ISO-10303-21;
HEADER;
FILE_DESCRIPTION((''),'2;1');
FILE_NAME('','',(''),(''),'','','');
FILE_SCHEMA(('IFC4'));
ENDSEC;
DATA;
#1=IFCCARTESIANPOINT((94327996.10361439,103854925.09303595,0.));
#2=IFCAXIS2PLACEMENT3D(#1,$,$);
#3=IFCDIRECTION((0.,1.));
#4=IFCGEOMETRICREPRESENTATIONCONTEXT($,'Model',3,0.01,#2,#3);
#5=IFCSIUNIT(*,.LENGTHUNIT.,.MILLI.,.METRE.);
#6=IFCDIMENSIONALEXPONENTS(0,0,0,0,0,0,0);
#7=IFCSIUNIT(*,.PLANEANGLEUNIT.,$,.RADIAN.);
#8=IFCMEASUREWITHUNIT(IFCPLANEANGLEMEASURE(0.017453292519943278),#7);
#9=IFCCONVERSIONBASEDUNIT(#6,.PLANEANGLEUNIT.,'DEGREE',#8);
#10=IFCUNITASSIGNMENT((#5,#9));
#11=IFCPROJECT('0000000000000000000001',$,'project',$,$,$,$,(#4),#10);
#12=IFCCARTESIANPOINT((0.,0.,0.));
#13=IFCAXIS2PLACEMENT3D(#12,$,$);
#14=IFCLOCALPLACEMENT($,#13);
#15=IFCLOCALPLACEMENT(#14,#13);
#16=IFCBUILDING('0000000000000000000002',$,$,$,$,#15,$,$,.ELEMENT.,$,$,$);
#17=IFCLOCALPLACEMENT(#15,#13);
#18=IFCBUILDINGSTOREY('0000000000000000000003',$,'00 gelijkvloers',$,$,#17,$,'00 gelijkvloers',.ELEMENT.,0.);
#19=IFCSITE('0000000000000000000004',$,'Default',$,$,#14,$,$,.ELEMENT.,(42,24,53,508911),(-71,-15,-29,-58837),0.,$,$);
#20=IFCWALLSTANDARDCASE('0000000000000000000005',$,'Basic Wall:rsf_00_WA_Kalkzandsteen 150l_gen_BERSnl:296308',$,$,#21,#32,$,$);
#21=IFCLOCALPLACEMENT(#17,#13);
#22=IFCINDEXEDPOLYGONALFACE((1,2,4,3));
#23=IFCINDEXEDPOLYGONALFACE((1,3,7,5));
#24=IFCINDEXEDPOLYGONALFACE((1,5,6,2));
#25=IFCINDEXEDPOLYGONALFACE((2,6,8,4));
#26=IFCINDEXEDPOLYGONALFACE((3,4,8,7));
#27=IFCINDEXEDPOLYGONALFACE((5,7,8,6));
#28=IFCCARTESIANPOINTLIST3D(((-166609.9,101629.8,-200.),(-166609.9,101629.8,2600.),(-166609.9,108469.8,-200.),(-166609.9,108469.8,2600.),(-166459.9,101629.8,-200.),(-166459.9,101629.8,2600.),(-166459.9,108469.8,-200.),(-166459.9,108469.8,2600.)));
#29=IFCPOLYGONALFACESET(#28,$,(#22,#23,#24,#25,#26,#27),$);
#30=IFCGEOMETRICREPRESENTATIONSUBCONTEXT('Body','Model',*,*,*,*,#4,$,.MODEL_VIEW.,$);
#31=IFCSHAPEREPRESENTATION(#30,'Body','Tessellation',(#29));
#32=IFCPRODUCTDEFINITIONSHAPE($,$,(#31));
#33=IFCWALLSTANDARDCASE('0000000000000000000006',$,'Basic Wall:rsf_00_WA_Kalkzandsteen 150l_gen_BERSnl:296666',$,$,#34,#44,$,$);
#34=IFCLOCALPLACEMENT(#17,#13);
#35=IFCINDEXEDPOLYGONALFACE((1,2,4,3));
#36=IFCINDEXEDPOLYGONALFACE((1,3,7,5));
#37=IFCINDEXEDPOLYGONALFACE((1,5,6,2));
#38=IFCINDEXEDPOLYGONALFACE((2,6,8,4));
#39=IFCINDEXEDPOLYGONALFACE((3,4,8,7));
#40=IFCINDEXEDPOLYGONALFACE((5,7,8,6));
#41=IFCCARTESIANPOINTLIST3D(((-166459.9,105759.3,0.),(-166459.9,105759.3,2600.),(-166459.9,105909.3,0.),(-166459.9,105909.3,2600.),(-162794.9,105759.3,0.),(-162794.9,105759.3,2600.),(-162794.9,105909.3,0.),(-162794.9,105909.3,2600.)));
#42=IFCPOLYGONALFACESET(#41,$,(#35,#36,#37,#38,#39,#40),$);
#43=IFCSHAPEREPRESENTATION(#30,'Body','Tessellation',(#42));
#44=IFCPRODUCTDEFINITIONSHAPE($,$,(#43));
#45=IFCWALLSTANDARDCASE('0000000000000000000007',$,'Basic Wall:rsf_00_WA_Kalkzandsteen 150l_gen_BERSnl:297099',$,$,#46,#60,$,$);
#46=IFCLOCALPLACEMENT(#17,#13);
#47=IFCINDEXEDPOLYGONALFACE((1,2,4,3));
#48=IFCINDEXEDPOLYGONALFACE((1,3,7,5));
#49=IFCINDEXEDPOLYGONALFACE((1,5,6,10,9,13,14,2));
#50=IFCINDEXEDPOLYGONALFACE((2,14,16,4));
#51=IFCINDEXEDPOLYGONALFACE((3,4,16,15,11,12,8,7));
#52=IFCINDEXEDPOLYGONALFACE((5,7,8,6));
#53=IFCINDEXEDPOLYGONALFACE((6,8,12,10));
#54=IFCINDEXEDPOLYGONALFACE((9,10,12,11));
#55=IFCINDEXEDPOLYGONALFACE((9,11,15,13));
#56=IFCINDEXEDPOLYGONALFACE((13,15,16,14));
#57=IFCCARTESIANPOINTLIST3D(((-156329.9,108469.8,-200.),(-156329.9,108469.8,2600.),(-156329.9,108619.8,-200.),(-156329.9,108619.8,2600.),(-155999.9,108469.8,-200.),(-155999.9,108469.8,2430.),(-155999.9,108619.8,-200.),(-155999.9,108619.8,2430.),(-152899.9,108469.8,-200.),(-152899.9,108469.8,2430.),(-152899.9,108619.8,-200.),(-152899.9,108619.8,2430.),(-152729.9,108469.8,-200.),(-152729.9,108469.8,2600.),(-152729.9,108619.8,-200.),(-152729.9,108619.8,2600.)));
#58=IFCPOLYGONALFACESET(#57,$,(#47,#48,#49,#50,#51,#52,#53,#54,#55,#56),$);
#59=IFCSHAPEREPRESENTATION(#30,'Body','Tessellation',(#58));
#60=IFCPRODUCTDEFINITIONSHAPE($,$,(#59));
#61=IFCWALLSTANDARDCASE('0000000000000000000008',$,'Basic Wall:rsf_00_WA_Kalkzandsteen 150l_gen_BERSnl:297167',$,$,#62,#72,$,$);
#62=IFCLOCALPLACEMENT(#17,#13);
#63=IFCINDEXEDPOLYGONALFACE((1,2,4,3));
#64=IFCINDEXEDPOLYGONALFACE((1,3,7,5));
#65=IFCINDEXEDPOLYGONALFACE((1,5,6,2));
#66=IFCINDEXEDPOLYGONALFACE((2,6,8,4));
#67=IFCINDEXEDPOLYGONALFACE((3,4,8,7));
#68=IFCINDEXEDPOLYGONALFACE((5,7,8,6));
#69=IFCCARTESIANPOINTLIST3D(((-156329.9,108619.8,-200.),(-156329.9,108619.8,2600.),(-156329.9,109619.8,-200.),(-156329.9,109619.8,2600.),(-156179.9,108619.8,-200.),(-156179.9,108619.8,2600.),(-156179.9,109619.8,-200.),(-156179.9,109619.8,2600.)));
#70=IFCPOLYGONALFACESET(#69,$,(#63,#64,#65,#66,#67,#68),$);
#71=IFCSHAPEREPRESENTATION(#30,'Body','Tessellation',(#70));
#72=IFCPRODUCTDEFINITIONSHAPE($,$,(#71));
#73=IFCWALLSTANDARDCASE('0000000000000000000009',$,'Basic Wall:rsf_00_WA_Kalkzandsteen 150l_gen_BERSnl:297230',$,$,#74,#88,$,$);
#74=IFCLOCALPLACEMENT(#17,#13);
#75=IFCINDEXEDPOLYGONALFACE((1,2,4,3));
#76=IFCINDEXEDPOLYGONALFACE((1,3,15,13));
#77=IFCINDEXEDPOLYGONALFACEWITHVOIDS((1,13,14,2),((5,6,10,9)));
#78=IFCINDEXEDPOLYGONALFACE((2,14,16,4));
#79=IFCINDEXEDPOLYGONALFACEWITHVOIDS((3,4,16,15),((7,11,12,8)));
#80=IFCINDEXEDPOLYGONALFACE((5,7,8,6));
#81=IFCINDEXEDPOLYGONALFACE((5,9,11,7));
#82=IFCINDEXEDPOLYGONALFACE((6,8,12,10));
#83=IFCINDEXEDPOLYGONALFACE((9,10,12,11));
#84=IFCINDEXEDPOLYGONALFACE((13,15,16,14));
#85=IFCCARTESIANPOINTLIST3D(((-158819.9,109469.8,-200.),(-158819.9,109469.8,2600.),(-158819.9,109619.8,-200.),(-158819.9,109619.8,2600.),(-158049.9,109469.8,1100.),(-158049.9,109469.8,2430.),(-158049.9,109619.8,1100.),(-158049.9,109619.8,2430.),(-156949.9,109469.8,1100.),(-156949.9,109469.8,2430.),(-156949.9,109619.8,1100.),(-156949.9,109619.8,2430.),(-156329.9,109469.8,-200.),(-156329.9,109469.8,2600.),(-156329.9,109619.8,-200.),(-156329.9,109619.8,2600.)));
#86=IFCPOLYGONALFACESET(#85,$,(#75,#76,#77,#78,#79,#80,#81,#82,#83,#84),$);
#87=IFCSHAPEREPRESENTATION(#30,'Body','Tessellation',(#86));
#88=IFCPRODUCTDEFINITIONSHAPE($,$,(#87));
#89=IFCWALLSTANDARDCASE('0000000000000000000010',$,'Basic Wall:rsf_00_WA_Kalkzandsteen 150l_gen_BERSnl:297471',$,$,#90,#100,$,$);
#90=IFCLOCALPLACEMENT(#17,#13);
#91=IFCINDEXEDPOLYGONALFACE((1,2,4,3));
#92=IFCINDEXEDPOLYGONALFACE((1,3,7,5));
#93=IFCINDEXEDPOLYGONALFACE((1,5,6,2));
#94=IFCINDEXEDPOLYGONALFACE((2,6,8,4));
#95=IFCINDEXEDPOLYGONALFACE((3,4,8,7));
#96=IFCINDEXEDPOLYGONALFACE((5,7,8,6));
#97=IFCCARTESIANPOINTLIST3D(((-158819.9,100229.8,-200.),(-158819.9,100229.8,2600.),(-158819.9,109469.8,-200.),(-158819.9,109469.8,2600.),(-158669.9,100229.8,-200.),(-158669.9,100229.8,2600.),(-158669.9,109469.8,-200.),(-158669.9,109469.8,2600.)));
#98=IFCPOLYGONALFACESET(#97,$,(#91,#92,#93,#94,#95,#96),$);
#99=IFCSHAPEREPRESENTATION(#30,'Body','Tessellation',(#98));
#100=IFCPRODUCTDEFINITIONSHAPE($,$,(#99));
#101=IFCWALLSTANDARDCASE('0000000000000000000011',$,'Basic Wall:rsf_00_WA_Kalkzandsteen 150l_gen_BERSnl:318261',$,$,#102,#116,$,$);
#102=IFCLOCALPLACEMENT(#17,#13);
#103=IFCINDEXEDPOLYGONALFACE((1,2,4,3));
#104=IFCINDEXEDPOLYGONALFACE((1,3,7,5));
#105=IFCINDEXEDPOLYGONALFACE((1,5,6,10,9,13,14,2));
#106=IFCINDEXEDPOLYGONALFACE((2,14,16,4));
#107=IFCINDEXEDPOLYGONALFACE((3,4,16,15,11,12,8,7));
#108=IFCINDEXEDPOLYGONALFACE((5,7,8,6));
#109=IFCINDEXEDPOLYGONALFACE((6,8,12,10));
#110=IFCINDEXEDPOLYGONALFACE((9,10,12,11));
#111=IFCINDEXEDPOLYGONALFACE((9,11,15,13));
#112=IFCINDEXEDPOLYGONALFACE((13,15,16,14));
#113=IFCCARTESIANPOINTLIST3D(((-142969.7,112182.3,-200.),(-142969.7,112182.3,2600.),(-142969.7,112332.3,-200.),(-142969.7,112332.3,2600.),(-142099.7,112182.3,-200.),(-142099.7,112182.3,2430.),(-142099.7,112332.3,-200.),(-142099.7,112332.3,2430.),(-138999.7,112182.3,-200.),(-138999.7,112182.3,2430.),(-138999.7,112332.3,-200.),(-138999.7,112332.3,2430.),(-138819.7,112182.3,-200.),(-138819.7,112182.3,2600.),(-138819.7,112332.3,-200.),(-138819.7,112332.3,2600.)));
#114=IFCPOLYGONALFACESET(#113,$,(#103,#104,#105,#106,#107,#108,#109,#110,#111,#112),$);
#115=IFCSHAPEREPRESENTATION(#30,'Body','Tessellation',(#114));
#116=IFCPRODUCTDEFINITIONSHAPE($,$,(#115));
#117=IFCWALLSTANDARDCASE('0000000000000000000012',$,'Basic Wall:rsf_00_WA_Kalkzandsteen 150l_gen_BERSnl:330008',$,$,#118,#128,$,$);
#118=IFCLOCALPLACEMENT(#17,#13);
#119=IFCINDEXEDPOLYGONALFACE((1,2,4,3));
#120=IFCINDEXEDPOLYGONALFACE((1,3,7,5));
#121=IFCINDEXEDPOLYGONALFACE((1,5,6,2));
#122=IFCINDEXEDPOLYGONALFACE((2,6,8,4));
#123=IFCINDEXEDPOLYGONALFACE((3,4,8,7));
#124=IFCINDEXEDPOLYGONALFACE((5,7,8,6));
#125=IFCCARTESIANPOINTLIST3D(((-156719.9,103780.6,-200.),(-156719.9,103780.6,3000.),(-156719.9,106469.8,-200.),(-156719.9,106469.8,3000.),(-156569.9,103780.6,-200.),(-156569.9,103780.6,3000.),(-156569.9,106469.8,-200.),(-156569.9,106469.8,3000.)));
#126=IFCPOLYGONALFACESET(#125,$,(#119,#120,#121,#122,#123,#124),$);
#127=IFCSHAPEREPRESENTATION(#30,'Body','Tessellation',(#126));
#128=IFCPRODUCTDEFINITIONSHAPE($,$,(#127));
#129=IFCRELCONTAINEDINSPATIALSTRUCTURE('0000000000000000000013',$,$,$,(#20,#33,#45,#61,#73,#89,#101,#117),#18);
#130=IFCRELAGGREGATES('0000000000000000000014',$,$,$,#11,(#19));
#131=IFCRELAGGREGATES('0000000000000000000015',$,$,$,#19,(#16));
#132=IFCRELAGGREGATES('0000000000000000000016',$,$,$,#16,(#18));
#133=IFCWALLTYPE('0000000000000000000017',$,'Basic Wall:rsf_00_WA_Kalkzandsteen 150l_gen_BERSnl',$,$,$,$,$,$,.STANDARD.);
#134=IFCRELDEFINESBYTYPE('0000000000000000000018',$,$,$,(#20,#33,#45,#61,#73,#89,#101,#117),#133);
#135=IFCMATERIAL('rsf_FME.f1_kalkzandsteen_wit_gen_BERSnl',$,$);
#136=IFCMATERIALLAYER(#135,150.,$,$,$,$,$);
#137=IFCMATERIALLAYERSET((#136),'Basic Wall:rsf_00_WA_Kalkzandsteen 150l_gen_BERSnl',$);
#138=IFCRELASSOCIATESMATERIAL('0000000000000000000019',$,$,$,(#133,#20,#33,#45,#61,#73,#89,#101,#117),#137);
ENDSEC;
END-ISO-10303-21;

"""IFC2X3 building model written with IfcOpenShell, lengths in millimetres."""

from ifc_helpers import new_model, entity, si_unit, converted_unit, direction, frame, frame_2d, origin, place, context, subcontext, project, spatial, polyline, rectangle, extrude, clip, bounded_halfspace, material, layer, layer_set, layer_usage, type_object, element, save


model = new_model("IFC2X3")

# Units and contexts
model_context = context("Model", 3, precision=0.01, world=frame((94327996.10361439, 103854925.09303595, 0.0)), true_north=direction((0.0, 1.0)))
body_context = subcontext(model_context, "Body", "Model", "MODEL_VIEW")
ifc_project = project(units=[si_unit("LENGTHUNIT", "METRE", prefix="MILLI"), converted_unit("PLANEANGLEUNIT", "DEGREE", entity("IfcPlaneAngleMeasure", 0.017453292519943278), si_unit("PLANEANGLEUNIT", "RADIAN"), dimensions=[0, 0, 0, 0, 0, 0, 0])], contexts=[model_context])

# Site, building, storey
site_placement = place(None, origin())
site = spatial("IfcSite", under=ifc_project, at=site_placement, Name="Default", CompositionType="ELEMENT", RefLatitude=(42, 24, 53, 508911), RefLongitude=(-71, -15, -29, -58837), RefElevation=0.0)
building_placement = place(site_placement, origin())
building = spatial("IfcBuilding", under=site, at=building_placement, CompositionType="ELEMENT")
storey_placement = place(building_placement, origin())
storey = spatial("IfcBuildingStorey", under=building, at=storey_placement, Name="00 gelijkvloers", LongName="00 gelijkvloers", CompositionType="ELEMENT", Elevation=0.0)

# Shared definitions
ifc_material_1 = material(Name="rsf_FME.f1_kalkzandsteen_wit_gen_BERSnl")
ifc_layer_1 = layer(ifc_material_1, 150.0)
ifc_layer_set_1 = layer_set([ifc_layer_1], Name="Basic Wall:rsf_00_WA_Kalkzandsteen 150l_gen_BERSnl")
wall_type_1 = type_object("IfcWallType", Name="Basic Wall:rsf_00_WA_Kalkzandsteen 150l_gen_BERSnl", PredefinedType="STANDARD", material=ifc_layer_set_1)

# Walls
ifc_layer_usage_1 = layer_usage(ifc_layer_set_1, "AXIS2", "NEGATIVE", 75.0)
wall_1_placement = place(storey_placement, frame((-166534.9, 108469.8, -200.0), z_axis=(0.0, 0.0, 1.0), x_axis=(0.0, -1.0, 0.0)))
element("IfcWallStandardCase", 1, at=wall_1_placement, inside=storey, type_object=wall_type_1, material=ifc_layer_usage_1, Name="Basic Wall:rsf_00_WA_Kalkzandsteen 150l_gen_BERSnl:296308", context=body_context, shape_type="Clipping", body=[
    clip(extrude(rectangle(XDim=6840.0, YDim=150.0, at=frame_2d((3420.0, 0.0), x_axis=(-1.0, 0.0))), origin(), (0.0, 0.0, 1.0), 2800.0), bounded_halfspace(frame((0.0, -75.0, 2800.0), z_axis=(0.0, 0.0, -1.0), x_axis=(-1.0, 0.0, 0.0)), True, frame((0.0, -75.0, 2800.0)), polyline([(0.0, 0.0), (6840.0, 0.0), (6840.0, 150.0), (2710.5, 150.0), (2560.5, 150.0), (0.0, 150.0), (0.0, 0.0)]))),
])
ifc_layer_usage_2 = layer_usage(ifc_layer_set_1, "AXIS2", "NEGATIVE", 75.0)
wall_2_placement = place(storey_placement, frame((-166459.9, 105834.3, 0.0)))
element("IfcWallStandardCase", 2, at=wall_2_placement, inside=storey, type_object=wall_type_1, material=ifc_layer_usage_2, Name="Basic Wall:rsf_00_WA_Kalkzandsteen 150l_gen_BERSnl:296666", context=body_context, shape_type="Clipping", body=[
    clip(extrude(rectangle(XDim=3665.0, YDim=150.0, at=frame_2d((1832.5, 0.0), x_axis=(-1.0, 0.0))), origin(), (0.0, 0.0, 1.0), 2600.0), bounded_halfspace(frame((0.0, -75.0, 2600.0), z_axis=(0.0, 0.0, -1.0), x_axis=(0.0, 1.0, 0.0)), True, frame((0.0, -75.0, 2600.0)), polyline([(0.0, 0.0), (3665.0, 0.0), (3665.0, 150.0), (0.0, 150.0), (0.0, 0.0)]))),
])

# Wall, opening
ifc_layer_usage_3 = layer_usage(ifc_layer_set_1, "AXIS2", "NEGATIVE", 75.0)
wall_3_placement = place(storey_placement, frame((-152729.9, 108544.8, -200.0), z_axis=(0.0, 0.0, 1.0), x_axis=(-1.0, 0.0, 0.0)))
wall_3 = element("IfcWallStandardCase", 3, at=wall_3_placement, inside=storey, type_object=wall_type_1, material=ifc_layer_usage_3, Name="Basic Wall:rsf_00_WA_Kalkzandsteen 150l_gen_BERSnl:297099", context=body_context, shape_type="Clipping", body=[
    clip(extrude(rectangle(XDim=3600.0, YDim=150.0, at=frame_2d((1800.0, 0.0), x_axis=(1.0, 0.0))), origin(), (0.0, 0.0, 1.0), 2800.0), bounded_halfspace(frame((0.0, -75.0, 2800.0), z_axis=(0.0, 0.0, -1.0), x_axis=(0.0, -1.0, 0.0)), True, frame((0.0, -75.0, 2800.0)), polyline([(0.0, 0.0), (3450.0, 0.0), (3600.0, 0.0), (3600.0, 150.0), (0.0, 150.0), (0.0, 0.0)]))),
])
opening_1_placement = place(wall_3_placement, frame((-152729.9, 108544.8, 200.0), z_axis=(0.0, 0.0, 1.0), x_axis=(-1.0, 0.0, 0.0)))
element("IfcOpeningElement", 4, at=opening_1_placement, cuts=wall_3, ObjectType="Opening", context=body_context, shape_type="SweptSolid", body=[
    extrude(rectangle(XDim=2630.0, YDim=3100.0, at=frame_2d((0.0, 0.0), x_axis=(0.0, 1.0))), frame((-154449.9, 110143.8, 1115.0), z_axis=(0.0, -1.0, 0.0), x_axis=(1.0, 0.0, 0.0)), (0.0, 0.0, 1.0), 3048.0),
])

# Wall
ifc_layer_usage_4 = layer_usage(ifc_layer_set_1, "AXIS2", "NEGATIVE", 75.0)
wall_4_placement = place(storey_placement, frame((-156254.9, 108619.8, -200.0), z_axis=(0.0, 0.0, 1.0), x_axis=(0.0, 1.0, 0.0)))
element("IfcWallStandardCase", 5, at=wall_4_placement, inside=storey, type_object=wall_type_1, material=ifc_layer_usage_4, Name="Basic Wall:rsf_00_WA_Kalkzandsteen 150l_gen_BERSnl:297167", context=body_context, shape_type="Clipping", body=[
    clip(extrude(rectangle(XDim=1000.0, YDim=150.0, at=frame_2d((500.0, 0.0), x_axis=(-1.0, 0.0))), origin(), (0.0, 0.0, 1.0), 2800.0), bounded_halfspace(frame((0.0, -75.0, 2800.0), z_axis=(0.0, 0.0, -1.0), x_axis=(1.0, 0.0, 0.0)), True, frame((0.0, -75.0, 2800.0)), polyline([(0.0, 0.0), (1000.0, 0.0), (1000.0, 150.0), (850.0, 150.0), (0.0, 150.0), (0.0, 0.0)]))),
])

# Wall, opening
ifc_layer_usage_5 = layer_usage(ifc_layer_set_1, "AXIS2", "NEGATIVE", 75.0)
wall_5_placement = place(storey_placement, frame((-156329.9, 109544.8, -200.0), z_axis=(0.0, 0.0, 1.0), x_axis=(-1.0, 0.0, 0.0)))
wall_5 = element("IfcWallStandardCase", 6, at=wall_5_placement, inside=storey, type_object=wall_type_1, material=ifc_layer_usage_5, Name="Basic Wall:rsf_00_WA_Kalkzandsteen 150l_gen_BERSnl:297230", context=body_context, shape_type="Clipping", body=[
    clip(extrude(rectangle(XDim=2490.0, YDim=150.0, at=frame_2d((1245.0, 0.0), x_axis=(-1.0, 0.0))), origin(), (0.0, 0.0, 1.0), 2800.0), bounded_halfspace(frame((0.0, -75.0, 2800.0), z_axis=(0.0, 0.0, -1.0), x_axis=(0.0, -1.0, 0.0)), True, frame((0.0, -75.0, 2800.0)), polyline([(0.0, 0.0), (2490.0, 0.0), (2490.0, 150.0), (2340.0, 150.0), (0.0, 150.0), (0.0, 0.0)]))),
])
opening_2_placement = place(wall_5_placement, frame((-156329.9, 109544.8, 200.0), z_axis=(0.0, 0.0, 1.0), x_axis=(-1.0, 0.0, 0.0)))
element("IfcOpeningElement", 7, at=opening_2_placement, cuts=wall_5, ObjectType="Opening", context=body_context, shape_type="SweptSolid", body=[
    extrude(rectangle(XDim=1330.0, YDim=1100.0, at=frame_2d((0.0, 0.0), x_axis=(1.0, 0.0))), frame((-157499.9, 110993.8, 1765.0), z_axis=(0.0, -1.0, 0.0), x_axis=(0.0, 0.0, 1.0)), (0.0, 0.0, 1.0), 3048.0),
])

# Wall
ifc_layer_usage_6 = layer_usage(ifc_layer_set_1, "AXIS2", "NEGATIVE", 75.0)
wall_6_placement = place(storey_placement, frame((-158744.9, 109469.8, -200.0), z_axis=(0.0, 0.0, 1.0), x_axis=(0.0, -1.0, 0.0)))
element("IfcWallStandardCase", 8, at=wall_6_placement, inside=storey, type_object=wall_type_1, material=ifc_layer_usage_6, Name="Basic Wall:rsf_00_WA_Kalkzandsteen 150l_gen_BERSnl:297471", context=body_context, shape_type="Clipping", body=[
    clip(extrude(rectangle(XDim=9240.0, YDim=150.0, at=frame_2d((4620.0, 0.0), x_axis=(-1.0, 0.0))), origin(), (0.0, 0.0, 1.0), 2800.0), bounded_halfspace(frame((0.0, -75.0, 2800.0), z_axis=(0.0, 0.0, -1.0), x_axis=(-1.0, 0.0, 0.0)), True, frame((0.0, -75.0, 2800.0)), polyline([(0.0, 0.0), (850.0, 0.0), (8394.1, 0.0), (9240.0, 0.0), (9240.0, 150.0), (0.0, 150.0), (0.0, 0.0)]))),
])

# Wall, opening
ifc_layer_usage_7 = layer_usage(ifc_layer_set_1, "AXIS2", "NEGATIVE", 75.0)
wall_7_placement = place(storey_placement, frame((-142969.7, 112257.3, -200.0)))
wall_7 = element("IfcWallStandardCase", 9, at=wall_7_placement, inside=storey, type_object=wall_type_1, material=ifc_layer_usage_7, Name="Basic Wall:rsf_00_WA_Kalkzandsteen 150l_gen_BERSnl:318261", context=body_context, shape_type="Clipping", body=[
    clip(extrude(rectangle(XDim=4150.0, YDim=150.0, at=frame_2d((2075.0, 0.0), x_axis=(-1.0, 0.0))), origin(), (0.0, 0.0, 1.0), 2800.0), bounded_halfspace(frame((0.0, -75.0, 2800.0), z_axis=(0.0, 0.0, -1.0), x_axis=(0.0, 1.0, 0.0)), True, frame((0.0, -75.0, 2800.0)), polyline([(0.0, 0.0), (150.0, 0.0), (4150.0, 0.0), (4150.0, 150.0), (0.0, 150.0), (0.0, 0.0)]))),
])
opening_3_placement = place(wall_7_placement, frame((142969.7, -112257.3, 200.0)))
element("IfcOpeningElement", 10, at=opening_3_placement, cuts=wall_7, ObjectType="Opening", context=body_context, shape_type="SweptSolid", body=[
    extrude(rectangle(XDim=2630.0, YDim=3100.0, at=frame_2d((0.0, 0.0), x_axis=(1.0, 0.0))), frame((-140549.7, 110808.3, 1115.0), z_axis=(0.0, 1.0, 0.0), x_axis=(0.0, 0.0, 1.0)), (0.0, 0.0, 1.0), 3048.0),
])

# Wall
ifc_layer_usage_8 = layer_usage(ifc_layer_set_1, "AXIS2", "NEGATIVE", 75.0)
wall_8_placement = place(storey_placement, frame((-156644.9, 106469.8, -200.0), z_axis=(0.0, 0.0, 1.0), x_axis=(0.0, -1.0, 0.0)))
element("IfcWallStandardCase", 11, at=wall_8_placement, inside=storey, type_object=wall_type_1, material=ifc_layer_usage_8, Name="Basic Wall:rsf_00_WA_Kalkzandsteen 150l_gen_BERSnl:330008", context=body_context, shape_type="SweptSolid", body=[
    extrude(rectangle(XDim=2689.2, YDim=150.0, at=frame_2d((1344.6, 0.0), x_axis=(-1.0, 0.0))), origin(), (0.0, 0.0, 1.0), 3200.0),
])

save(model, "model.ifc")
